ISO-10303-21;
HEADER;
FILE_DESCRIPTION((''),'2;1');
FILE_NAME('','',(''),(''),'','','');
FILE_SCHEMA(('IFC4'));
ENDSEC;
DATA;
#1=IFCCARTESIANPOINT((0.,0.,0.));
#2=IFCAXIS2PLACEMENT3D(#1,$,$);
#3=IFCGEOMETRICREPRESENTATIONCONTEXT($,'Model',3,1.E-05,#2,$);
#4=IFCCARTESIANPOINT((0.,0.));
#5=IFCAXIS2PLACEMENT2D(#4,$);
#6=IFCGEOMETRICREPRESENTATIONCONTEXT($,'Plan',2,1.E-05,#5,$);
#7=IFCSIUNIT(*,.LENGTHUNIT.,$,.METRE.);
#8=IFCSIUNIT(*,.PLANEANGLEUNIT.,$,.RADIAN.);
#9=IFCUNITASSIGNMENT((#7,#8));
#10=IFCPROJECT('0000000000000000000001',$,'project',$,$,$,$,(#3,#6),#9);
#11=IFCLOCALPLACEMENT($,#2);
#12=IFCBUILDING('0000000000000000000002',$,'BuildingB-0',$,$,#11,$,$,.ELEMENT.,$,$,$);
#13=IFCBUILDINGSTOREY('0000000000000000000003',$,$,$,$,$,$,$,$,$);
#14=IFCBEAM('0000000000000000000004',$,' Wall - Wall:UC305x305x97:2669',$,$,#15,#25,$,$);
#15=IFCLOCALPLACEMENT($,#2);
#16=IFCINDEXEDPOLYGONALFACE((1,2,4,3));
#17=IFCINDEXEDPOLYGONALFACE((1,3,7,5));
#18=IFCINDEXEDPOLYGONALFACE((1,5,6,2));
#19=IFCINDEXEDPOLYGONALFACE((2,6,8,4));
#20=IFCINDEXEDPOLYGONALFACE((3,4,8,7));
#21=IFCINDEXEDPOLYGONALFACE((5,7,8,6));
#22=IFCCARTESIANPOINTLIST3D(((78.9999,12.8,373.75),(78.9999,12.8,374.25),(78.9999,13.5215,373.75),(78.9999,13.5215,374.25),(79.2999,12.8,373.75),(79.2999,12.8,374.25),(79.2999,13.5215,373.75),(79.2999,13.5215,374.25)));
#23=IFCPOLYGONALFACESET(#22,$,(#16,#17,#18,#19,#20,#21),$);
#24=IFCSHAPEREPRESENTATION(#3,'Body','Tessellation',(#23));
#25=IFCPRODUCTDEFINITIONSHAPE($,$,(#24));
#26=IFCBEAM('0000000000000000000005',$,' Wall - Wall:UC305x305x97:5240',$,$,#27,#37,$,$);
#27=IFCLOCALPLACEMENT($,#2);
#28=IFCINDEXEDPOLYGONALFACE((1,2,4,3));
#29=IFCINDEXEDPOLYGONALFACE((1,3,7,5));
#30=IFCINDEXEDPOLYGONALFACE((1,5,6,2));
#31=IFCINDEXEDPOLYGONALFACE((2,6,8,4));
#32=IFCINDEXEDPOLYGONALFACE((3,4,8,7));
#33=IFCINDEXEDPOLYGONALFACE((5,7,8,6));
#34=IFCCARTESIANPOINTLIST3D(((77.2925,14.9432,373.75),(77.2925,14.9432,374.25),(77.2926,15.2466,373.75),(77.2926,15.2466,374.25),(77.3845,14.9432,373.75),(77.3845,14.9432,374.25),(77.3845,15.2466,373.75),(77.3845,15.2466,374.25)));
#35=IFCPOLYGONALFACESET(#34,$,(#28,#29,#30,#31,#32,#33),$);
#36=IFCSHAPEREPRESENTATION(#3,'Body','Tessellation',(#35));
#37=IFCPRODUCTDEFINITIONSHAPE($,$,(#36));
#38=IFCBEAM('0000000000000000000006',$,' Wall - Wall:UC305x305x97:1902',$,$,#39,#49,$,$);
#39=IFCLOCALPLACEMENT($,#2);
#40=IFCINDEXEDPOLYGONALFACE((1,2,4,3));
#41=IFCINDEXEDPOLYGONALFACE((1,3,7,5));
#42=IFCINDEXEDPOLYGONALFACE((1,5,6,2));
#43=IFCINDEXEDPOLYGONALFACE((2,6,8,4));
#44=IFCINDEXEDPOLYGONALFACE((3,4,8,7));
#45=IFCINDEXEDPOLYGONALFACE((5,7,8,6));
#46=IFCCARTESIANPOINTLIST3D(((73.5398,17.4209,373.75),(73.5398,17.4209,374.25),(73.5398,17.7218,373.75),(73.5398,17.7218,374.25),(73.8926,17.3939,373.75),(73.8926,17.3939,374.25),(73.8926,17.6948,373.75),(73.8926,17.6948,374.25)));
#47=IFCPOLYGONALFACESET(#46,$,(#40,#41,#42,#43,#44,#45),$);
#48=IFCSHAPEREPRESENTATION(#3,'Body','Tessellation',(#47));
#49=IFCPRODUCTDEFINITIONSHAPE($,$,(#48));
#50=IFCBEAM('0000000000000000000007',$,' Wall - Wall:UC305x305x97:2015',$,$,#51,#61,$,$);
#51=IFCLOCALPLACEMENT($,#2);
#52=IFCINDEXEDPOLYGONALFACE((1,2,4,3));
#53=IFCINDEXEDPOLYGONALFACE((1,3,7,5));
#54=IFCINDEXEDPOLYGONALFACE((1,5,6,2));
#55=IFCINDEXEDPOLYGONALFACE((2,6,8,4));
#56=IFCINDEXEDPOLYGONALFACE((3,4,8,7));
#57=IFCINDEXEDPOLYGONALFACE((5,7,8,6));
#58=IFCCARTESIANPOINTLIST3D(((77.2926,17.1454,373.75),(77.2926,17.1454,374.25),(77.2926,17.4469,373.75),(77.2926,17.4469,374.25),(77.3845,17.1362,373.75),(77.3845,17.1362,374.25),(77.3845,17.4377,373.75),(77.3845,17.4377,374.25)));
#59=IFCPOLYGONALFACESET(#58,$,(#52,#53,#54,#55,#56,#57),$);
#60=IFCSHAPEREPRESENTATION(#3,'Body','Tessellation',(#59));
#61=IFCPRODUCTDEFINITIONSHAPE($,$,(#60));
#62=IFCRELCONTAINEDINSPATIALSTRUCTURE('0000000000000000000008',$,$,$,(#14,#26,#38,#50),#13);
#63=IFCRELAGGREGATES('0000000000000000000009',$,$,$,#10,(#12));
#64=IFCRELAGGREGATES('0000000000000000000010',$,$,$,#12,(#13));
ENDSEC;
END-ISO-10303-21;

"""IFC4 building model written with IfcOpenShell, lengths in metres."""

from ifc_helpers import new_model, si_unit, origin, origin_2d, place, context, project, spatial, polyline, outline, extrude, element, save


model = new_model("IFC4")

# Units and contexts
model_context = context("Model", 3, precision=1e-05, world=origin())
plan_context = context("Plan", 2, precision=1e-05, world=origin_2d())
ifc_project = project(units=[si_unit("LENGTHUNIT", "METRE"), si_unit("PLANEANGLEUNIT", "RADIAN")], contexts=[model_context, plan_context])

# Building, storey
building_placement = place(None, origin())
building = spatial("IfcBuilding", under=ifc_project, at=building_placement, Name="BuildingB-0", CompositionType="ELEMENT")
storey = spatial("IfcBuildingStorey", under=building)

# Beams
element("IfcBeam", 1, inside=storey, Name=" Wall - Wall:UC305x305x97:2669", context=model_context, shape_type="SweptSolid", body=[
    extrude(outline(polyline([(79.2999, 12.8, 373.75), (78.9999, 12.8, 373.75), (78.9999, 13.5215, 373.75), (79.2999, 13.5215, 373.75), (79.2999, 12.8, 373.75)])), None, (0.0, 0.0, 1.0), 0.5),
])
element("IfcBeam", 2, inside=storey, Name=" Wall - Wall:UC305x305x97:5240", context=model_context, shape_type="SweptSolid", body=[
    extrude(outline(polyline([(77.3845, 14.9432, 373.75), (77.2925, 14.9432, 373.75), (77.2926, 15.2466, 373.75), (77.3845, 15.2466, 373.75), (77.3845, 14.9432, 373.75)])), None, (0.0, 0.0, 1.0), 0.5),
])
element("IfcBeam", 3, inside=storey, Name=" Wall - Wall:UC305x305x97:1902", context=model_context, shape_type="SweptSolid", body=[
    extrude(outline(polyline([(73.8926, 17.3939, 373.75), (73.5398, 17.4209, 373.75), (73.5398, 17.7218, 373.75), (73.8926, 17.6948, 373.75), (73.8926, 17.3939, 373.75)])), None, (0.0, 0.0, 1.0), 0.5),
])
element("IfcBeam", 4, inside=storey, Name=" Wall - Wall:UC305x305x97:2015", context=model_context, shape_type="SweptSolid", body=[
    extrude(outline(polyline([(77.3845, 17.1362, 373.75), (77.2926, 17.1454, 373.75), (77.2926, 17.4469, 373.75), (77.3845, 17.4377, 373.75), (77.3845, 17.1362, 373.75)])), None, (0.0, 0.0, 1.0), 0.5),
])

save(model, "model.ifc")
